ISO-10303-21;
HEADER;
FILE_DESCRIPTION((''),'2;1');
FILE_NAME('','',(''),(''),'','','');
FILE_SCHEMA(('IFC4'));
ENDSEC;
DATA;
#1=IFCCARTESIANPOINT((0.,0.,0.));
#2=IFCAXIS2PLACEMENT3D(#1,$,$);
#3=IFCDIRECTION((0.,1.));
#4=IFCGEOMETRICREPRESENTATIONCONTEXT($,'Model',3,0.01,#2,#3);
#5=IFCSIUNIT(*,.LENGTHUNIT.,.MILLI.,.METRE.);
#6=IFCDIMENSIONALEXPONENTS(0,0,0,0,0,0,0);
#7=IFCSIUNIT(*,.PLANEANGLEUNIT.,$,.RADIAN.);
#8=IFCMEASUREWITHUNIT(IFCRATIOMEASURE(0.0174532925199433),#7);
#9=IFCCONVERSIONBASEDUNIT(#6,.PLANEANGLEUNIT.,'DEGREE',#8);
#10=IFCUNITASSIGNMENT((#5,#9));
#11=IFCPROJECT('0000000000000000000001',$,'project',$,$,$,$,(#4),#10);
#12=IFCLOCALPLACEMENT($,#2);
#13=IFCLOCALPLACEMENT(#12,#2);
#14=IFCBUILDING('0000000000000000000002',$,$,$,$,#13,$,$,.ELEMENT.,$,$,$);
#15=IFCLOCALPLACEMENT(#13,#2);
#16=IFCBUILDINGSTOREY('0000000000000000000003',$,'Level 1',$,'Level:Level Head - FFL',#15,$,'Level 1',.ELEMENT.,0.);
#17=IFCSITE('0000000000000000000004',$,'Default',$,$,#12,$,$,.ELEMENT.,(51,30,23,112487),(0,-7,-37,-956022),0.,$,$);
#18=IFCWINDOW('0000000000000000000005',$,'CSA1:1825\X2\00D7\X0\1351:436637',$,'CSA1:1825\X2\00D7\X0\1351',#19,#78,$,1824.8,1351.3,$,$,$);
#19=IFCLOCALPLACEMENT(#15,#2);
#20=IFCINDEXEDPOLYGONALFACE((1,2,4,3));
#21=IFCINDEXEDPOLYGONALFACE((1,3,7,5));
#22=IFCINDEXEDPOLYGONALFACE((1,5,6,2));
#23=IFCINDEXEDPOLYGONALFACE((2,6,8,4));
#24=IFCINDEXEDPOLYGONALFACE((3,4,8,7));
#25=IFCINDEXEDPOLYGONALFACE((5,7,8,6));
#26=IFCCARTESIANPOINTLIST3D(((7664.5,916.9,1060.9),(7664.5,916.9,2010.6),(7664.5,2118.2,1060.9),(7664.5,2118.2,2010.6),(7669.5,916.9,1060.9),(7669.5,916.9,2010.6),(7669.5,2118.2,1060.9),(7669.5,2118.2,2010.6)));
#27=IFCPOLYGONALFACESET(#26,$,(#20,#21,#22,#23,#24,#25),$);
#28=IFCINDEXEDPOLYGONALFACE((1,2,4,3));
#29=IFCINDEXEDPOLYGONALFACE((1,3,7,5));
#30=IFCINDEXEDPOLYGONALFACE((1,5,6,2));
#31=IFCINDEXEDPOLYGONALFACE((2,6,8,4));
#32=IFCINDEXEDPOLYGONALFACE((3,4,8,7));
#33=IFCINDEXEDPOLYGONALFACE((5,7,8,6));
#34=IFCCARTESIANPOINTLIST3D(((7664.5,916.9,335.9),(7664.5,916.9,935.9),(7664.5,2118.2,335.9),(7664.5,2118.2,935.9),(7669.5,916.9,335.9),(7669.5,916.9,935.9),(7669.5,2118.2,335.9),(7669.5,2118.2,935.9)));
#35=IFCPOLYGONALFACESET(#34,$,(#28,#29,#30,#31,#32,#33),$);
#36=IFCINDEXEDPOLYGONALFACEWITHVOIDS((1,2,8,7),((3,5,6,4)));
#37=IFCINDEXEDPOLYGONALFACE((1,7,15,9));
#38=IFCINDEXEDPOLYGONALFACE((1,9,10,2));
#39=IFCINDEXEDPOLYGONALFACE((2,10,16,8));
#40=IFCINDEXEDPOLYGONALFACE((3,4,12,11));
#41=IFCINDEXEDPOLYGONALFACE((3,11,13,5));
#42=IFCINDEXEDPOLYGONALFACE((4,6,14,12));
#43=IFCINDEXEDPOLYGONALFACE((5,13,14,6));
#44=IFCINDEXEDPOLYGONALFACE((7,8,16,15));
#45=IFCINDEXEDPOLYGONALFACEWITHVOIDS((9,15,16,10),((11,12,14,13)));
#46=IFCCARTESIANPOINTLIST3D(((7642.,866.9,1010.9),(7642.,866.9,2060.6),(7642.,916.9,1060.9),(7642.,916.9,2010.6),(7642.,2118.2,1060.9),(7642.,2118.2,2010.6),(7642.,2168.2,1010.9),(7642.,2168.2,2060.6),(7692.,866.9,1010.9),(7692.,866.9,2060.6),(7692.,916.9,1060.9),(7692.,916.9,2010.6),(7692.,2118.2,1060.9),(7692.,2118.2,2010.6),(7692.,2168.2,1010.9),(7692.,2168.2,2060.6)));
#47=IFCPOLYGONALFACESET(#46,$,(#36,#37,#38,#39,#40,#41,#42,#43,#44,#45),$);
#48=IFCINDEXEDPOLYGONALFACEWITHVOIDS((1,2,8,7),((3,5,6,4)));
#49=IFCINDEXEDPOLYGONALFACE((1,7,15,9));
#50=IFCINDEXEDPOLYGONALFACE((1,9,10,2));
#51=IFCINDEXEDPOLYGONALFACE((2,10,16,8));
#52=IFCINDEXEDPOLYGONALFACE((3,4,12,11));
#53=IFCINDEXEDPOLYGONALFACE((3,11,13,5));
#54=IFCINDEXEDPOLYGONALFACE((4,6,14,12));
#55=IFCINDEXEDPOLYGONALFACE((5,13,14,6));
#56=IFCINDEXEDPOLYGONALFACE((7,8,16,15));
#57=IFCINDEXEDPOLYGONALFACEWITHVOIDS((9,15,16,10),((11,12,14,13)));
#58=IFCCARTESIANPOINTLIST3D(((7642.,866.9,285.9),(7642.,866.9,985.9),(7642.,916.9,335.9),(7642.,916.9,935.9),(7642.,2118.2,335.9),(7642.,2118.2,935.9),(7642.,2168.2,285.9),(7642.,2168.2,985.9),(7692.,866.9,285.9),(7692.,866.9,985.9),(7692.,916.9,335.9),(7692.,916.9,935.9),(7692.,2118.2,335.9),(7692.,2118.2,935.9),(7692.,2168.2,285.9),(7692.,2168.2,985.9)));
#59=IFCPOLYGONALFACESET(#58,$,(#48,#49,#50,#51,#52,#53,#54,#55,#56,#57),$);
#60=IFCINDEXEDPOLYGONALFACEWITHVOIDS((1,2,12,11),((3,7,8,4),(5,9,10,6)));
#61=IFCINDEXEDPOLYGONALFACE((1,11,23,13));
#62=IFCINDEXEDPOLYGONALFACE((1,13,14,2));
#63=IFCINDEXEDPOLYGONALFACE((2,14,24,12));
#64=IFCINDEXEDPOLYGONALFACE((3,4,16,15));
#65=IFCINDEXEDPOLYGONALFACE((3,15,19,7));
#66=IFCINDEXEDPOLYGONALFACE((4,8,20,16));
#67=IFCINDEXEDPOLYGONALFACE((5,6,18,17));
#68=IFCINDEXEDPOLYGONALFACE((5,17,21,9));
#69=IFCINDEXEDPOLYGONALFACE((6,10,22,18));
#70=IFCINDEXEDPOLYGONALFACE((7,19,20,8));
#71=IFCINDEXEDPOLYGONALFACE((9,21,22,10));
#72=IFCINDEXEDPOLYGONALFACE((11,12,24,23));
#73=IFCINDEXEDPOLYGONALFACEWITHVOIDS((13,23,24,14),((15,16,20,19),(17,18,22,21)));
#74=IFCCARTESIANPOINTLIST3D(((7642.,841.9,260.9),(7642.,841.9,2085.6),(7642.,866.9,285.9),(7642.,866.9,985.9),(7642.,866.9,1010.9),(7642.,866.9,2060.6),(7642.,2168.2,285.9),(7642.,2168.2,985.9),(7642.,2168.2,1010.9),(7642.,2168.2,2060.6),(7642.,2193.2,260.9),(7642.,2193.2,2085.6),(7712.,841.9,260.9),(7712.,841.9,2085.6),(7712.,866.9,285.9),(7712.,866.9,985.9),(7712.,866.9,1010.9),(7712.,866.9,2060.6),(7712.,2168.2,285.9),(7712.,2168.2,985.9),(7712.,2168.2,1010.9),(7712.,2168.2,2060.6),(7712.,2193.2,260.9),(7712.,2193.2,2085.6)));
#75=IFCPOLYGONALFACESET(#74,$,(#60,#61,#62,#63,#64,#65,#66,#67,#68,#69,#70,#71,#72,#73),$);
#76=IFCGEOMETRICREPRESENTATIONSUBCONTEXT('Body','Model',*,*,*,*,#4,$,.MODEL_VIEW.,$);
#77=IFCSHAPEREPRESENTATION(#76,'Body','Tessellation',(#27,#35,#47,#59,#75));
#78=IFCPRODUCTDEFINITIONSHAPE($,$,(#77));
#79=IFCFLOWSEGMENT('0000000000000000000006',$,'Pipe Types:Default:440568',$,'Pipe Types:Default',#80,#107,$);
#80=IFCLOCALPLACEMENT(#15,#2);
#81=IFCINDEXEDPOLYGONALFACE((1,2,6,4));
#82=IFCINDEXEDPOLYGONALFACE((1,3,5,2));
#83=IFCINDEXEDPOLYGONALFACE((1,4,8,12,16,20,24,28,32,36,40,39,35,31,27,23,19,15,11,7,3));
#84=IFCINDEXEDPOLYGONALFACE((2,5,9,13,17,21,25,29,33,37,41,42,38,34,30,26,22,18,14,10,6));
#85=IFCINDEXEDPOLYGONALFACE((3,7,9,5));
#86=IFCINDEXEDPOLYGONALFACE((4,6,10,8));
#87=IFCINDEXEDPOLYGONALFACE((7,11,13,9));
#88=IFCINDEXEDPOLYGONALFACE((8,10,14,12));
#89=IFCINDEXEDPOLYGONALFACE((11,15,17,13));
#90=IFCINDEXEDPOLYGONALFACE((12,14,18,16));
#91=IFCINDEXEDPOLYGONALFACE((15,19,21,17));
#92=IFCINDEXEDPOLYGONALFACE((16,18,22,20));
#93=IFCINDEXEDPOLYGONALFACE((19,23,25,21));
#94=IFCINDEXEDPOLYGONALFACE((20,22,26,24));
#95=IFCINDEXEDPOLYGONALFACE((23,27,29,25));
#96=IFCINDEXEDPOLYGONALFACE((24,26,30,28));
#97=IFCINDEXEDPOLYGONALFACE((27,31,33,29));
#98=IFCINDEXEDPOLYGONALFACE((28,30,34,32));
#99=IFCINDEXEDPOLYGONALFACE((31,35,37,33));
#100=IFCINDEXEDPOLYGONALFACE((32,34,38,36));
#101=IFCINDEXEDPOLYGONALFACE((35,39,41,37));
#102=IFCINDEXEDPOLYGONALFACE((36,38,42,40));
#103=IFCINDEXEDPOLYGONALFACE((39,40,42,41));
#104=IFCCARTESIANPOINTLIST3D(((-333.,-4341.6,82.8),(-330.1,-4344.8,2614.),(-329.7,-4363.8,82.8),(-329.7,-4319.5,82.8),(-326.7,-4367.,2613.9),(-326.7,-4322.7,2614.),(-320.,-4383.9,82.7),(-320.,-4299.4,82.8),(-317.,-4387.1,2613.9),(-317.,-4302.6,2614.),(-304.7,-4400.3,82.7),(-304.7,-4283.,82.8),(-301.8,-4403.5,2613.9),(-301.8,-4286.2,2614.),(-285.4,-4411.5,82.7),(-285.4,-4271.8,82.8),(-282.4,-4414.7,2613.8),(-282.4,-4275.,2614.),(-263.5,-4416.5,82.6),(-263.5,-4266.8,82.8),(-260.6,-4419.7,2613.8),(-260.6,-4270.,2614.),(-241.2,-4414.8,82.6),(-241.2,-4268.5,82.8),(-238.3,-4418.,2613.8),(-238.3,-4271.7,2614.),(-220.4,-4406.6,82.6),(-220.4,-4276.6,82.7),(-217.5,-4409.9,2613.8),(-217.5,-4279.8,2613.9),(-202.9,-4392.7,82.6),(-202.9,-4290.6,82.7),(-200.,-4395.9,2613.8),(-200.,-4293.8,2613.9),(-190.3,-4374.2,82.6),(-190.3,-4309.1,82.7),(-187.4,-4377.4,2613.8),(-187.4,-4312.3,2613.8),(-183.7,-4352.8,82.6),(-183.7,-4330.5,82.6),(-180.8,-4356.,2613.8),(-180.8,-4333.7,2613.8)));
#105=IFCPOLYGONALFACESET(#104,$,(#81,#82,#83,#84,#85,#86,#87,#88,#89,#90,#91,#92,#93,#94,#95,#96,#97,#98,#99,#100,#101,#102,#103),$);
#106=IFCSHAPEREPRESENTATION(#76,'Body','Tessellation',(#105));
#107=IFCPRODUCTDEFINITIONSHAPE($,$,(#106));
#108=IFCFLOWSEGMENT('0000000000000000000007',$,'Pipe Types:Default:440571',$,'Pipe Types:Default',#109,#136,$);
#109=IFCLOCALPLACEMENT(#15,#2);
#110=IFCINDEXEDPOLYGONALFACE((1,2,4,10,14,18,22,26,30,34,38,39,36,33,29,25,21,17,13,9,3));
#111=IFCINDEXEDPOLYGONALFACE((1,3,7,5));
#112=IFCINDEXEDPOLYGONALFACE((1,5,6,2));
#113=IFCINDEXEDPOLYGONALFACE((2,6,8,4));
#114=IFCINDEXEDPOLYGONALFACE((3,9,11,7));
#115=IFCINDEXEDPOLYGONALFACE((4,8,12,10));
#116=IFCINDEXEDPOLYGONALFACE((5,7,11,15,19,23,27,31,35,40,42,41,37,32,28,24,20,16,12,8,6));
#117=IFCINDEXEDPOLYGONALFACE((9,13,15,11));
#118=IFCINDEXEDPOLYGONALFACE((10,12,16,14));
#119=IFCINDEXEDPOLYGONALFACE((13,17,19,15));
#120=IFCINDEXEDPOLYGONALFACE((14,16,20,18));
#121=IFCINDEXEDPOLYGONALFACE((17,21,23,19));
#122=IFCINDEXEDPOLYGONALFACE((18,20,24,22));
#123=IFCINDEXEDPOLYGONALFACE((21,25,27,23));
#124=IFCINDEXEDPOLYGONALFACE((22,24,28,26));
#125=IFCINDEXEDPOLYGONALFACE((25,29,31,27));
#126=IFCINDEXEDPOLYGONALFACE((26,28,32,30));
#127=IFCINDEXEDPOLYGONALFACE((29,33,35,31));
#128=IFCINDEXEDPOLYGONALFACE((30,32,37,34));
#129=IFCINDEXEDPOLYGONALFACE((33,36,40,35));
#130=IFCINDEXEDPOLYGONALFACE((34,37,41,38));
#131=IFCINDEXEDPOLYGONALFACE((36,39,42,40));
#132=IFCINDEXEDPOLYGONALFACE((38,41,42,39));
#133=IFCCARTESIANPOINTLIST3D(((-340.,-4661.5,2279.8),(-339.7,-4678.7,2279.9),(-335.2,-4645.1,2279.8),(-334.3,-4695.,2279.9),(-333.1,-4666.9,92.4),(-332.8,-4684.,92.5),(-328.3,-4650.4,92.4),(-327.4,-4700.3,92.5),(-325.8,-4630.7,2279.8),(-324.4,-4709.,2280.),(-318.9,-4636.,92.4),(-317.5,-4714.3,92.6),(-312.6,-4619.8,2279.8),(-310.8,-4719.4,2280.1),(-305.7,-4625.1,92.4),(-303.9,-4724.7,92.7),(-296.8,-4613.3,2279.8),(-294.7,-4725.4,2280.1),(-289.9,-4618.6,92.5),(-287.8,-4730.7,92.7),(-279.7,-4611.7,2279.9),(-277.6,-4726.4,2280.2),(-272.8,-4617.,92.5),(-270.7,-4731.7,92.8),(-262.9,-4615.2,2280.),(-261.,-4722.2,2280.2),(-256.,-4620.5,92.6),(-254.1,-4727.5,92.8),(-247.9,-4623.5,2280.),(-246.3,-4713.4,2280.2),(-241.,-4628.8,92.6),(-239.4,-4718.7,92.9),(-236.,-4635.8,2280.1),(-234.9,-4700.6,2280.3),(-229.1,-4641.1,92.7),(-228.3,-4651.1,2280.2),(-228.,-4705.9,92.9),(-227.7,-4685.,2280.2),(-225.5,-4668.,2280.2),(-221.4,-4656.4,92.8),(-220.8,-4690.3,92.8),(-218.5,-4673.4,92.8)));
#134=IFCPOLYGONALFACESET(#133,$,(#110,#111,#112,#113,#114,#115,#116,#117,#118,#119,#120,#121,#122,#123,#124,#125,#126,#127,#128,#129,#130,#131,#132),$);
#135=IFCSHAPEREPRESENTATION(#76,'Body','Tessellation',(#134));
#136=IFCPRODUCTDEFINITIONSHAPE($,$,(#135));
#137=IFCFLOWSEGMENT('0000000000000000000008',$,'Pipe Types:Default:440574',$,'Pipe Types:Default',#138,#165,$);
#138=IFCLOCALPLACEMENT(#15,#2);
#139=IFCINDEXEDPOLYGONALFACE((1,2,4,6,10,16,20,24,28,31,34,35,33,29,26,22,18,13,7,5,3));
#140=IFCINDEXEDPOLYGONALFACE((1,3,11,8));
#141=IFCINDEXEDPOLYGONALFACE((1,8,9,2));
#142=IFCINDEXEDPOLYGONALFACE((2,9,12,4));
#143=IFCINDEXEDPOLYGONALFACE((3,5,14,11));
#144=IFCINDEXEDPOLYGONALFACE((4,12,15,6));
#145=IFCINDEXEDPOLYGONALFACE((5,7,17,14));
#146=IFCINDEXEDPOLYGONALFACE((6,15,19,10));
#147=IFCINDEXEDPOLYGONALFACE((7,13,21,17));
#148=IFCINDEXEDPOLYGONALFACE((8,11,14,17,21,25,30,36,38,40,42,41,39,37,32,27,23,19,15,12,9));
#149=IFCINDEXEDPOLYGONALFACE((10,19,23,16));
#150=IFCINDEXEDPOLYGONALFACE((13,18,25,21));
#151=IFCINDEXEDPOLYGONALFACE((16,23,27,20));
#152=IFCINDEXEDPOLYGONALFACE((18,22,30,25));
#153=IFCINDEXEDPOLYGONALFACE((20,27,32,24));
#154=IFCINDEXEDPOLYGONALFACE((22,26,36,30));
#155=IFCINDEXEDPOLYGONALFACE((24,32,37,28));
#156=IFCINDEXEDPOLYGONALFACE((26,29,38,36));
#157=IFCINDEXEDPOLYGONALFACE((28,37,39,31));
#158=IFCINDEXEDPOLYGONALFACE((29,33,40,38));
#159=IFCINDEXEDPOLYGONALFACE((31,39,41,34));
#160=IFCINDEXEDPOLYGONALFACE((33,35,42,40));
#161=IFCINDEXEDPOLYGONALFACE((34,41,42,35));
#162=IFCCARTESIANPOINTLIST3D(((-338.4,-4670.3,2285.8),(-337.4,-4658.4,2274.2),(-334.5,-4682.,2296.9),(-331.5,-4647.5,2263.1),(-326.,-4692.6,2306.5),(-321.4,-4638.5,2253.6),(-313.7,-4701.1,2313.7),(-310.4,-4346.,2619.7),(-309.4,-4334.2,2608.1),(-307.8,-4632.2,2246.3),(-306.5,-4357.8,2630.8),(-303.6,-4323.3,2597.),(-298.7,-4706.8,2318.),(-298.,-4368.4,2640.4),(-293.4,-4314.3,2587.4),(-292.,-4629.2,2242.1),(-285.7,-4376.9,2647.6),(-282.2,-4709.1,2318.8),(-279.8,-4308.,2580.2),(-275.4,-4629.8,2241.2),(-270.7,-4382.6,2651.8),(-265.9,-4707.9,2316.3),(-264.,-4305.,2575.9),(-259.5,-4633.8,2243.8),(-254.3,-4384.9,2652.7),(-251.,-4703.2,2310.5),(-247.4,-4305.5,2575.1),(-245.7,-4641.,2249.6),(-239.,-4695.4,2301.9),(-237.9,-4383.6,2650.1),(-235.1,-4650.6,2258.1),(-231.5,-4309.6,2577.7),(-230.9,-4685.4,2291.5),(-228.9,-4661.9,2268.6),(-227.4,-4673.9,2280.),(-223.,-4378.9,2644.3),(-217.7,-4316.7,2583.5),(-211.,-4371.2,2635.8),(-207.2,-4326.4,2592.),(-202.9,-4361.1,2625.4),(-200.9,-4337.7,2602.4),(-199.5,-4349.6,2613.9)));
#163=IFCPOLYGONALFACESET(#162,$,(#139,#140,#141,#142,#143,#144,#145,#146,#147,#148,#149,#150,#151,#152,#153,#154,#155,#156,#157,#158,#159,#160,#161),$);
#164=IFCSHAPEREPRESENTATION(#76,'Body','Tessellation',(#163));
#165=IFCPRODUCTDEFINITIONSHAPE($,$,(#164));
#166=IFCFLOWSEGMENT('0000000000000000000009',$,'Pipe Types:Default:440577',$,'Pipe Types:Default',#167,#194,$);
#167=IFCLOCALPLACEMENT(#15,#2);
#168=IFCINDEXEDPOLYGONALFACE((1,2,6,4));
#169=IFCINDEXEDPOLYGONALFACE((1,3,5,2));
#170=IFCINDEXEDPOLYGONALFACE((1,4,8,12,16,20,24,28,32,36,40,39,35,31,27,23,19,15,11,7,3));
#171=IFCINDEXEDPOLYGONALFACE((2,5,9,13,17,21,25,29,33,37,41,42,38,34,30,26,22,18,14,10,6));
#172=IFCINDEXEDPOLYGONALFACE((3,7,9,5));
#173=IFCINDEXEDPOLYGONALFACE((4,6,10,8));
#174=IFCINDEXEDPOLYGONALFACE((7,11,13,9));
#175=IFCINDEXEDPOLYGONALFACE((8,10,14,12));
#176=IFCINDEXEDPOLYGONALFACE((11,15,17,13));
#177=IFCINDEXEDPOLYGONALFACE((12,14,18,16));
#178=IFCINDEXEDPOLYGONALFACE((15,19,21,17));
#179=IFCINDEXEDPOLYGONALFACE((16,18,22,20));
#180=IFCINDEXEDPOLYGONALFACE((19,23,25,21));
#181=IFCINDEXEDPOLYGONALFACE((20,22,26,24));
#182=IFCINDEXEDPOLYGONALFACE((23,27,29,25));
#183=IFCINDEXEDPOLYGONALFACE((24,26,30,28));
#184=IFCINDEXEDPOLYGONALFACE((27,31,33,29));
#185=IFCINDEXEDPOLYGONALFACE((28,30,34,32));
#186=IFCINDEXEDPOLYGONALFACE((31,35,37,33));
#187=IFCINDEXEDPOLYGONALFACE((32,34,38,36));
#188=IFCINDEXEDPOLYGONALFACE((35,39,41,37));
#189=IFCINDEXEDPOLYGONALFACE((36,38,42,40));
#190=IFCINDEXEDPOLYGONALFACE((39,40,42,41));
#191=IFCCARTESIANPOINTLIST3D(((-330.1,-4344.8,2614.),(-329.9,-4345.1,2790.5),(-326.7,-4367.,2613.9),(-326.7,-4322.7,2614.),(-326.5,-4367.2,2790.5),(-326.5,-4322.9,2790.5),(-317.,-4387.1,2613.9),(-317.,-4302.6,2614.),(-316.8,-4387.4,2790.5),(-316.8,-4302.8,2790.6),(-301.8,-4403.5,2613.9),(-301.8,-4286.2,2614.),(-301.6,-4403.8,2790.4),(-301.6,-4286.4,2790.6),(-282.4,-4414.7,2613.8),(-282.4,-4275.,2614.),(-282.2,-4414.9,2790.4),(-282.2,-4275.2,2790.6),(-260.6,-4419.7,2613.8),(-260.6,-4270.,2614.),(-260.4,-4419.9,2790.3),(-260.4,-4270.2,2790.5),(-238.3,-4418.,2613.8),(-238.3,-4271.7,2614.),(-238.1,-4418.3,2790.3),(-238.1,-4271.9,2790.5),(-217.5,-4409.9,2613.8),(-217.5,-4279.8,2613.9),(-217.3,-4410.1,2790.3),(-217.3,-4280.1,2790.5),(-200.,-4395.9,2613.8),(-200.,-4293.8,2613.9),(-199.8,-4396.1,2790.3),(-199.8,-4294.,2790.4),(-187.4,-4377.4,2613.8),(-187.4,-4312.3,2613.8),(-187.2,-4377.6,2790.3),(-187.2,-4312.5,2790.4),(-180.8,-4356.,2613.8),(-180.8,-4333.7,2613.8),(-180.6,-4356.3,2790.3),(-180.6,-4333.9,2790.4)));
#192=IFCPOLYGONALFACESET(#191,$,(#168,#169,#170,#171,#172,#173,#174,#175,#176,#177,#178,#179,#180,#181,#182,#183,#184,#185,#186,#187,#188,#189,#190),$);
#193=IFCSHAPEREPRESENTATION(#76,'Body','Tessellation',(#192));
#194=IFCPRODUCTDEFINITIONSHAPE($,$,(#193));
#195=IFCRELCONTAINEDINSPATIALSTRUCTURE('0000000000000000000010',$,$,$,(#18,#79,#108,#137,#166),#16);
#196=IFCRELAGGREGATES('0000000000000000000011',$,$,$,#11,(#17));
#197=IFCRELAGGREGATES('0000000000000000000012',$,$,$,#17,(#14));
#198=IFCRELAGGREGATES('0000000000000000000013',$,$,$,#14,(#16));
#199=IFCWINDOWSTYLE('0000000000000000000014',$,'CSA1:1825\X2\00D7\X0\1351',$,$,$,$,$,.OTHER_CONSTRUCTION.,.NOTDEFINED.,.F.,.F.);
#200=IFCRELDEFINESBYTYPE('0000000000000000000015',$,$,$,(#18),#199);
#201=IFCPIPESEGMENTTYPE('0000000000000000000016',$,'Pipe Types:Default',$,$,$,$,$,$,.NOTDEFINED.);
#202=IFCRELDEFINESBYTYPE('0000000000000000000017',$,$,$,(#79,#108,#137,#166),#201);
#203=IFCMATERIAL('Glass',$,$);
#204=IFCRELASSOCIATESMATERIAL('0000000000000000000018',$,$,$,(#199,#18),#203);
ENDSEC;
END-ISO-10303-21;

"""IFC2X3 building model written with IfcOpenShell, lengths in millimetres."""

from ifc_helpers import new_model, entity, si_unit, converted_unit, direction, frame, frame_2d, origin, origin_2d_with_axis, place, context, subcontext, project, spatial, polyline, rectangle, circle, outline, extrude, source, transform, mapped, material, type_object, type_shapes, element, save


model = new_model("IFC2X3")

# Units and contexts
model_context = context("Model", 3, precision=0.01, world=origin(), true_north=direction((0.0, 1.0)))
body_context = subcontext(model_context, "Body", "Model", "MODEL_VIEW")
ifc_project = project(units=[si_unit("LENGTHUNIT", "METRE", prefix="MILLI"), converted_unit("PLANEANGLEUNIT", "DEGREE", entity("IfcRatioMeasure", 0.0174532925199433), si_unit("PLANEANGLEUNIT", "RADIAN"), dimensions=[0, 0, 0, 0, 0, 0, 0])], contexts=[model_context])

# Site, building, storey
site_placement = place(None, origin())
site = spatial("IfcSite", under=ifc_project, at=site_placement, Name="Default", CompositionType="ELEMENT", RefLatitude=(51, 30, 23, 112487), RefLongitude=(0, -7, -37, -956022), RefElevation=0.0)
building_placement = place(site_placement, origin())
building = spatial("IfcBuilding", under=site, at=building_placement, CompositionType="ELEMENT")
storey_placement = place(building_placement, origin())
storey = spatial("IfcBuildingStorey", under=building, at=storey_placement, Name="Level 1", ObjectType="Level:Level Head - FFL", LongName="Level 1", CompositionType="ELEMENT", Elevation=0.0)

# Window
ifc_material_1 = material(Name="Glass")
window_style_1 = type_object("IfcWindowStyle", Name="CSA1:1825×1351", ConstructionType="OTHER_CONSTRUCTION", OperationType="NOTDEFINED", ParameterTakesPrecedence=False, Sizeable=False, material=ifc_material_1)
shared_shape_1 = source(origin(), body_context, "Body", "SweptSolid", [
    extrude(rectangle(XDim=5.0, YDim=1201.3, at=origin_2d_with_axis()), frame((675.6, 45.0, 800.0), z_axis=(0.0, 0.0, 1.0), x_axis=(0.0, 1.0, 0.0)), (0.0, 0.0, 1.0), 949.8),
    extrude(rectangle(XDim=5.0, YDim=1201.3, at=origin_2d_with_axis()), frame((675.6, 45.0, 75.0), z_axis=(0.0, 0.0, 1.0), x_axis=(0.0, 1.0, 0.0)), (0.0, 0.0, 1.0), 600.0),
    extrude(outline(polyline([(-650.6, -524.9), (650.6, -524.9), (650.6, 524.9), (-650.6, 524.9), (-650.6, -524.9)]), holes=[polyline([(-600.6, -474.9), (-600.6, 474.9), (600.6, 474.9), (600.6, -474.9), (-600.6, -474.9)])]), frame((675.6, 20.0, 1274.9), z_axis=(0.0, 1.0, 0.0), x_axis=(1.0, 0.0, 0.0)), (0.0, 0.0, 1.0), 50.0),
    extrude(outline(polyline([(-650.6, -350.0), (650.6, -350.0), (650.6, 350.0), (-650.6, 350.0), (-650.6, -350.0)]), holes=[polyline([(-600.6, -300.0), (-600.6, 300.0), (600.6, 300.0), (600.6, -300.0), (-600.6, -300.0)])]), frame((675.6, 20.0, 375.0), z_axis=(0.0, 1.0, 0.0), x_axis=(1.0, 0.0, 0.0)), (0.0, 0.0, 1.0), 50.0),
    extrude(outline(polyline([(-675.6, -912.4), (675.6, -912.4), (675.6, 912.4), (-675.6, 912.4), (-675.6, -912.4)]), holes=[polyline([(-650.6, -887.4), (-650.6, 162.4), (650.6, 162.4), (650.6, -887.4), (-650.6, -887.4)]), polyline([(-650.6, 187.4), (-650.6, 887.4), (650.6, 887.4), (650.6, 187.4), (-650.6, 187.4)])]), frame((675.6, 0.0, 912.4), z_axis=(0.0, 1.0, 0.0), x_axis=(1.0, 0.0, 0.0)), (0.0, 0.0, 1.0), 70.0),
])
type_shapes(window_style_1, [shared_shape_1])
window_1_placement = place(storey_placement, frame((7712.0, 841.9, 260.9), z_axis=(0.0, 0.0, 1.0), x_axis=(0.0, 1.0, 0.0)))
element("IfcWindow", 1, at=window_1_placement, inside=storey, type_object=window_style_1, material=ifc_material_1, Name="CSA1:1825×1351:436637", ObjectType="CSA1:1825×1351", OverallHeight=1824.8, OverallWidth=1351.3, context=body_context, shape_type="MappedRepresentation", body=[
    mapped(shared_shape_1, transform((0.0, 0.0, 0.0), scale=1.0)),
])

# Flow segments
pipe_segment_type = type_object("IfcPipeSegmentType", Name="Pipe Types:Default", PredefinedType="NOTDEFINED")
flow_segment_1_placement = place(storey_placement, origin())
element("IfcFlowSegment", 2, at=flow_segment_1_placement, inside=storey, type_object=pipe_segment_type, Name="Pipe Types:Default:440568", ObjectType="Pipe Types:Default", context=body_context, shape_type="SweptSolid", body=[
    extrude(circle(Radius=75.1, at=frame_2d((0.0, 0.0), x_axis=(1.0, 0.0))), frame((-257.9, -4341.6, 82.7), z_axis=(0.00116, -0.001268, 0.999999), x_axis=(-0.999999, 0.0, 0.00116)), (0.0, 0.0, 1.0), 2531.2),
])
flow_segment_2_placement = place(storey_placement, origin())
element("IfcFlowSegment", 3, at=flow_segment_2_placement, inside=storey, type_object=pipe_segment_type, Name="Pipe Types:Default:440571", ObjectType="Pipe Types:Default", context=body_context, shape_type="SweptSolid", body=[
    extrude(circle(Radius=57.5, at=frame_2d((0.0, 0.0), x_axis=(1.0, 0.0))), frame((-276.1, -4674.4, 92.6), z_axis=(-0.00316, 0.002428, 0.999992), x_axis=(0.609187, 0.793026, 0.0)), (0.0, 0.0, 1.0), 2187.4),
])
flow_segment_3_placement = place(storey_placement, origin())
element("IfcFlowSegment", 4, at=flow_segment_3_placement, inside=storey, type_object=pipe_segment_type, Name="Pipe Types:Default:440574", ObjectType="Pipe Types:Default", context=body_context, shape_type="SweptSolid", body=[
    extrude(circle(Radius=55.8, at=origin_2d_with_axis()), frame((-283.0, -4669.1, 2280.0), z_axis=(0.059995, 0.695438, 0.716078), x_axis=(0.996299, -0.085951, 0.0)), (0.0, 0.0, 1.0), 466.2),
])
flow_segment_4_placement = place(storey_placement, origin())
element("IfcFlowSegment", 5, at=flow_segment_4_placement, inside=storey, type_object=pipe_segment_type, Name="Pipe Types:Default:440577", ObjectType="Pipe Types:Default", context=body_context, shape_type="SweptSolid", body=[
    extrude(circle(Radius=75.1, at=frame_2d((0.0, 0.0), x_axis=(1.0, 0.0))), frame((-255.0, -4344.8, 2613.9), z_axis=(0.00116, -0.001268, 0.999999), x_axis=(-0.999999, 0.0, 0.00116)), (0.0, 0.0, 1.0), 176.6),
])

save(model, "model.ifc")
